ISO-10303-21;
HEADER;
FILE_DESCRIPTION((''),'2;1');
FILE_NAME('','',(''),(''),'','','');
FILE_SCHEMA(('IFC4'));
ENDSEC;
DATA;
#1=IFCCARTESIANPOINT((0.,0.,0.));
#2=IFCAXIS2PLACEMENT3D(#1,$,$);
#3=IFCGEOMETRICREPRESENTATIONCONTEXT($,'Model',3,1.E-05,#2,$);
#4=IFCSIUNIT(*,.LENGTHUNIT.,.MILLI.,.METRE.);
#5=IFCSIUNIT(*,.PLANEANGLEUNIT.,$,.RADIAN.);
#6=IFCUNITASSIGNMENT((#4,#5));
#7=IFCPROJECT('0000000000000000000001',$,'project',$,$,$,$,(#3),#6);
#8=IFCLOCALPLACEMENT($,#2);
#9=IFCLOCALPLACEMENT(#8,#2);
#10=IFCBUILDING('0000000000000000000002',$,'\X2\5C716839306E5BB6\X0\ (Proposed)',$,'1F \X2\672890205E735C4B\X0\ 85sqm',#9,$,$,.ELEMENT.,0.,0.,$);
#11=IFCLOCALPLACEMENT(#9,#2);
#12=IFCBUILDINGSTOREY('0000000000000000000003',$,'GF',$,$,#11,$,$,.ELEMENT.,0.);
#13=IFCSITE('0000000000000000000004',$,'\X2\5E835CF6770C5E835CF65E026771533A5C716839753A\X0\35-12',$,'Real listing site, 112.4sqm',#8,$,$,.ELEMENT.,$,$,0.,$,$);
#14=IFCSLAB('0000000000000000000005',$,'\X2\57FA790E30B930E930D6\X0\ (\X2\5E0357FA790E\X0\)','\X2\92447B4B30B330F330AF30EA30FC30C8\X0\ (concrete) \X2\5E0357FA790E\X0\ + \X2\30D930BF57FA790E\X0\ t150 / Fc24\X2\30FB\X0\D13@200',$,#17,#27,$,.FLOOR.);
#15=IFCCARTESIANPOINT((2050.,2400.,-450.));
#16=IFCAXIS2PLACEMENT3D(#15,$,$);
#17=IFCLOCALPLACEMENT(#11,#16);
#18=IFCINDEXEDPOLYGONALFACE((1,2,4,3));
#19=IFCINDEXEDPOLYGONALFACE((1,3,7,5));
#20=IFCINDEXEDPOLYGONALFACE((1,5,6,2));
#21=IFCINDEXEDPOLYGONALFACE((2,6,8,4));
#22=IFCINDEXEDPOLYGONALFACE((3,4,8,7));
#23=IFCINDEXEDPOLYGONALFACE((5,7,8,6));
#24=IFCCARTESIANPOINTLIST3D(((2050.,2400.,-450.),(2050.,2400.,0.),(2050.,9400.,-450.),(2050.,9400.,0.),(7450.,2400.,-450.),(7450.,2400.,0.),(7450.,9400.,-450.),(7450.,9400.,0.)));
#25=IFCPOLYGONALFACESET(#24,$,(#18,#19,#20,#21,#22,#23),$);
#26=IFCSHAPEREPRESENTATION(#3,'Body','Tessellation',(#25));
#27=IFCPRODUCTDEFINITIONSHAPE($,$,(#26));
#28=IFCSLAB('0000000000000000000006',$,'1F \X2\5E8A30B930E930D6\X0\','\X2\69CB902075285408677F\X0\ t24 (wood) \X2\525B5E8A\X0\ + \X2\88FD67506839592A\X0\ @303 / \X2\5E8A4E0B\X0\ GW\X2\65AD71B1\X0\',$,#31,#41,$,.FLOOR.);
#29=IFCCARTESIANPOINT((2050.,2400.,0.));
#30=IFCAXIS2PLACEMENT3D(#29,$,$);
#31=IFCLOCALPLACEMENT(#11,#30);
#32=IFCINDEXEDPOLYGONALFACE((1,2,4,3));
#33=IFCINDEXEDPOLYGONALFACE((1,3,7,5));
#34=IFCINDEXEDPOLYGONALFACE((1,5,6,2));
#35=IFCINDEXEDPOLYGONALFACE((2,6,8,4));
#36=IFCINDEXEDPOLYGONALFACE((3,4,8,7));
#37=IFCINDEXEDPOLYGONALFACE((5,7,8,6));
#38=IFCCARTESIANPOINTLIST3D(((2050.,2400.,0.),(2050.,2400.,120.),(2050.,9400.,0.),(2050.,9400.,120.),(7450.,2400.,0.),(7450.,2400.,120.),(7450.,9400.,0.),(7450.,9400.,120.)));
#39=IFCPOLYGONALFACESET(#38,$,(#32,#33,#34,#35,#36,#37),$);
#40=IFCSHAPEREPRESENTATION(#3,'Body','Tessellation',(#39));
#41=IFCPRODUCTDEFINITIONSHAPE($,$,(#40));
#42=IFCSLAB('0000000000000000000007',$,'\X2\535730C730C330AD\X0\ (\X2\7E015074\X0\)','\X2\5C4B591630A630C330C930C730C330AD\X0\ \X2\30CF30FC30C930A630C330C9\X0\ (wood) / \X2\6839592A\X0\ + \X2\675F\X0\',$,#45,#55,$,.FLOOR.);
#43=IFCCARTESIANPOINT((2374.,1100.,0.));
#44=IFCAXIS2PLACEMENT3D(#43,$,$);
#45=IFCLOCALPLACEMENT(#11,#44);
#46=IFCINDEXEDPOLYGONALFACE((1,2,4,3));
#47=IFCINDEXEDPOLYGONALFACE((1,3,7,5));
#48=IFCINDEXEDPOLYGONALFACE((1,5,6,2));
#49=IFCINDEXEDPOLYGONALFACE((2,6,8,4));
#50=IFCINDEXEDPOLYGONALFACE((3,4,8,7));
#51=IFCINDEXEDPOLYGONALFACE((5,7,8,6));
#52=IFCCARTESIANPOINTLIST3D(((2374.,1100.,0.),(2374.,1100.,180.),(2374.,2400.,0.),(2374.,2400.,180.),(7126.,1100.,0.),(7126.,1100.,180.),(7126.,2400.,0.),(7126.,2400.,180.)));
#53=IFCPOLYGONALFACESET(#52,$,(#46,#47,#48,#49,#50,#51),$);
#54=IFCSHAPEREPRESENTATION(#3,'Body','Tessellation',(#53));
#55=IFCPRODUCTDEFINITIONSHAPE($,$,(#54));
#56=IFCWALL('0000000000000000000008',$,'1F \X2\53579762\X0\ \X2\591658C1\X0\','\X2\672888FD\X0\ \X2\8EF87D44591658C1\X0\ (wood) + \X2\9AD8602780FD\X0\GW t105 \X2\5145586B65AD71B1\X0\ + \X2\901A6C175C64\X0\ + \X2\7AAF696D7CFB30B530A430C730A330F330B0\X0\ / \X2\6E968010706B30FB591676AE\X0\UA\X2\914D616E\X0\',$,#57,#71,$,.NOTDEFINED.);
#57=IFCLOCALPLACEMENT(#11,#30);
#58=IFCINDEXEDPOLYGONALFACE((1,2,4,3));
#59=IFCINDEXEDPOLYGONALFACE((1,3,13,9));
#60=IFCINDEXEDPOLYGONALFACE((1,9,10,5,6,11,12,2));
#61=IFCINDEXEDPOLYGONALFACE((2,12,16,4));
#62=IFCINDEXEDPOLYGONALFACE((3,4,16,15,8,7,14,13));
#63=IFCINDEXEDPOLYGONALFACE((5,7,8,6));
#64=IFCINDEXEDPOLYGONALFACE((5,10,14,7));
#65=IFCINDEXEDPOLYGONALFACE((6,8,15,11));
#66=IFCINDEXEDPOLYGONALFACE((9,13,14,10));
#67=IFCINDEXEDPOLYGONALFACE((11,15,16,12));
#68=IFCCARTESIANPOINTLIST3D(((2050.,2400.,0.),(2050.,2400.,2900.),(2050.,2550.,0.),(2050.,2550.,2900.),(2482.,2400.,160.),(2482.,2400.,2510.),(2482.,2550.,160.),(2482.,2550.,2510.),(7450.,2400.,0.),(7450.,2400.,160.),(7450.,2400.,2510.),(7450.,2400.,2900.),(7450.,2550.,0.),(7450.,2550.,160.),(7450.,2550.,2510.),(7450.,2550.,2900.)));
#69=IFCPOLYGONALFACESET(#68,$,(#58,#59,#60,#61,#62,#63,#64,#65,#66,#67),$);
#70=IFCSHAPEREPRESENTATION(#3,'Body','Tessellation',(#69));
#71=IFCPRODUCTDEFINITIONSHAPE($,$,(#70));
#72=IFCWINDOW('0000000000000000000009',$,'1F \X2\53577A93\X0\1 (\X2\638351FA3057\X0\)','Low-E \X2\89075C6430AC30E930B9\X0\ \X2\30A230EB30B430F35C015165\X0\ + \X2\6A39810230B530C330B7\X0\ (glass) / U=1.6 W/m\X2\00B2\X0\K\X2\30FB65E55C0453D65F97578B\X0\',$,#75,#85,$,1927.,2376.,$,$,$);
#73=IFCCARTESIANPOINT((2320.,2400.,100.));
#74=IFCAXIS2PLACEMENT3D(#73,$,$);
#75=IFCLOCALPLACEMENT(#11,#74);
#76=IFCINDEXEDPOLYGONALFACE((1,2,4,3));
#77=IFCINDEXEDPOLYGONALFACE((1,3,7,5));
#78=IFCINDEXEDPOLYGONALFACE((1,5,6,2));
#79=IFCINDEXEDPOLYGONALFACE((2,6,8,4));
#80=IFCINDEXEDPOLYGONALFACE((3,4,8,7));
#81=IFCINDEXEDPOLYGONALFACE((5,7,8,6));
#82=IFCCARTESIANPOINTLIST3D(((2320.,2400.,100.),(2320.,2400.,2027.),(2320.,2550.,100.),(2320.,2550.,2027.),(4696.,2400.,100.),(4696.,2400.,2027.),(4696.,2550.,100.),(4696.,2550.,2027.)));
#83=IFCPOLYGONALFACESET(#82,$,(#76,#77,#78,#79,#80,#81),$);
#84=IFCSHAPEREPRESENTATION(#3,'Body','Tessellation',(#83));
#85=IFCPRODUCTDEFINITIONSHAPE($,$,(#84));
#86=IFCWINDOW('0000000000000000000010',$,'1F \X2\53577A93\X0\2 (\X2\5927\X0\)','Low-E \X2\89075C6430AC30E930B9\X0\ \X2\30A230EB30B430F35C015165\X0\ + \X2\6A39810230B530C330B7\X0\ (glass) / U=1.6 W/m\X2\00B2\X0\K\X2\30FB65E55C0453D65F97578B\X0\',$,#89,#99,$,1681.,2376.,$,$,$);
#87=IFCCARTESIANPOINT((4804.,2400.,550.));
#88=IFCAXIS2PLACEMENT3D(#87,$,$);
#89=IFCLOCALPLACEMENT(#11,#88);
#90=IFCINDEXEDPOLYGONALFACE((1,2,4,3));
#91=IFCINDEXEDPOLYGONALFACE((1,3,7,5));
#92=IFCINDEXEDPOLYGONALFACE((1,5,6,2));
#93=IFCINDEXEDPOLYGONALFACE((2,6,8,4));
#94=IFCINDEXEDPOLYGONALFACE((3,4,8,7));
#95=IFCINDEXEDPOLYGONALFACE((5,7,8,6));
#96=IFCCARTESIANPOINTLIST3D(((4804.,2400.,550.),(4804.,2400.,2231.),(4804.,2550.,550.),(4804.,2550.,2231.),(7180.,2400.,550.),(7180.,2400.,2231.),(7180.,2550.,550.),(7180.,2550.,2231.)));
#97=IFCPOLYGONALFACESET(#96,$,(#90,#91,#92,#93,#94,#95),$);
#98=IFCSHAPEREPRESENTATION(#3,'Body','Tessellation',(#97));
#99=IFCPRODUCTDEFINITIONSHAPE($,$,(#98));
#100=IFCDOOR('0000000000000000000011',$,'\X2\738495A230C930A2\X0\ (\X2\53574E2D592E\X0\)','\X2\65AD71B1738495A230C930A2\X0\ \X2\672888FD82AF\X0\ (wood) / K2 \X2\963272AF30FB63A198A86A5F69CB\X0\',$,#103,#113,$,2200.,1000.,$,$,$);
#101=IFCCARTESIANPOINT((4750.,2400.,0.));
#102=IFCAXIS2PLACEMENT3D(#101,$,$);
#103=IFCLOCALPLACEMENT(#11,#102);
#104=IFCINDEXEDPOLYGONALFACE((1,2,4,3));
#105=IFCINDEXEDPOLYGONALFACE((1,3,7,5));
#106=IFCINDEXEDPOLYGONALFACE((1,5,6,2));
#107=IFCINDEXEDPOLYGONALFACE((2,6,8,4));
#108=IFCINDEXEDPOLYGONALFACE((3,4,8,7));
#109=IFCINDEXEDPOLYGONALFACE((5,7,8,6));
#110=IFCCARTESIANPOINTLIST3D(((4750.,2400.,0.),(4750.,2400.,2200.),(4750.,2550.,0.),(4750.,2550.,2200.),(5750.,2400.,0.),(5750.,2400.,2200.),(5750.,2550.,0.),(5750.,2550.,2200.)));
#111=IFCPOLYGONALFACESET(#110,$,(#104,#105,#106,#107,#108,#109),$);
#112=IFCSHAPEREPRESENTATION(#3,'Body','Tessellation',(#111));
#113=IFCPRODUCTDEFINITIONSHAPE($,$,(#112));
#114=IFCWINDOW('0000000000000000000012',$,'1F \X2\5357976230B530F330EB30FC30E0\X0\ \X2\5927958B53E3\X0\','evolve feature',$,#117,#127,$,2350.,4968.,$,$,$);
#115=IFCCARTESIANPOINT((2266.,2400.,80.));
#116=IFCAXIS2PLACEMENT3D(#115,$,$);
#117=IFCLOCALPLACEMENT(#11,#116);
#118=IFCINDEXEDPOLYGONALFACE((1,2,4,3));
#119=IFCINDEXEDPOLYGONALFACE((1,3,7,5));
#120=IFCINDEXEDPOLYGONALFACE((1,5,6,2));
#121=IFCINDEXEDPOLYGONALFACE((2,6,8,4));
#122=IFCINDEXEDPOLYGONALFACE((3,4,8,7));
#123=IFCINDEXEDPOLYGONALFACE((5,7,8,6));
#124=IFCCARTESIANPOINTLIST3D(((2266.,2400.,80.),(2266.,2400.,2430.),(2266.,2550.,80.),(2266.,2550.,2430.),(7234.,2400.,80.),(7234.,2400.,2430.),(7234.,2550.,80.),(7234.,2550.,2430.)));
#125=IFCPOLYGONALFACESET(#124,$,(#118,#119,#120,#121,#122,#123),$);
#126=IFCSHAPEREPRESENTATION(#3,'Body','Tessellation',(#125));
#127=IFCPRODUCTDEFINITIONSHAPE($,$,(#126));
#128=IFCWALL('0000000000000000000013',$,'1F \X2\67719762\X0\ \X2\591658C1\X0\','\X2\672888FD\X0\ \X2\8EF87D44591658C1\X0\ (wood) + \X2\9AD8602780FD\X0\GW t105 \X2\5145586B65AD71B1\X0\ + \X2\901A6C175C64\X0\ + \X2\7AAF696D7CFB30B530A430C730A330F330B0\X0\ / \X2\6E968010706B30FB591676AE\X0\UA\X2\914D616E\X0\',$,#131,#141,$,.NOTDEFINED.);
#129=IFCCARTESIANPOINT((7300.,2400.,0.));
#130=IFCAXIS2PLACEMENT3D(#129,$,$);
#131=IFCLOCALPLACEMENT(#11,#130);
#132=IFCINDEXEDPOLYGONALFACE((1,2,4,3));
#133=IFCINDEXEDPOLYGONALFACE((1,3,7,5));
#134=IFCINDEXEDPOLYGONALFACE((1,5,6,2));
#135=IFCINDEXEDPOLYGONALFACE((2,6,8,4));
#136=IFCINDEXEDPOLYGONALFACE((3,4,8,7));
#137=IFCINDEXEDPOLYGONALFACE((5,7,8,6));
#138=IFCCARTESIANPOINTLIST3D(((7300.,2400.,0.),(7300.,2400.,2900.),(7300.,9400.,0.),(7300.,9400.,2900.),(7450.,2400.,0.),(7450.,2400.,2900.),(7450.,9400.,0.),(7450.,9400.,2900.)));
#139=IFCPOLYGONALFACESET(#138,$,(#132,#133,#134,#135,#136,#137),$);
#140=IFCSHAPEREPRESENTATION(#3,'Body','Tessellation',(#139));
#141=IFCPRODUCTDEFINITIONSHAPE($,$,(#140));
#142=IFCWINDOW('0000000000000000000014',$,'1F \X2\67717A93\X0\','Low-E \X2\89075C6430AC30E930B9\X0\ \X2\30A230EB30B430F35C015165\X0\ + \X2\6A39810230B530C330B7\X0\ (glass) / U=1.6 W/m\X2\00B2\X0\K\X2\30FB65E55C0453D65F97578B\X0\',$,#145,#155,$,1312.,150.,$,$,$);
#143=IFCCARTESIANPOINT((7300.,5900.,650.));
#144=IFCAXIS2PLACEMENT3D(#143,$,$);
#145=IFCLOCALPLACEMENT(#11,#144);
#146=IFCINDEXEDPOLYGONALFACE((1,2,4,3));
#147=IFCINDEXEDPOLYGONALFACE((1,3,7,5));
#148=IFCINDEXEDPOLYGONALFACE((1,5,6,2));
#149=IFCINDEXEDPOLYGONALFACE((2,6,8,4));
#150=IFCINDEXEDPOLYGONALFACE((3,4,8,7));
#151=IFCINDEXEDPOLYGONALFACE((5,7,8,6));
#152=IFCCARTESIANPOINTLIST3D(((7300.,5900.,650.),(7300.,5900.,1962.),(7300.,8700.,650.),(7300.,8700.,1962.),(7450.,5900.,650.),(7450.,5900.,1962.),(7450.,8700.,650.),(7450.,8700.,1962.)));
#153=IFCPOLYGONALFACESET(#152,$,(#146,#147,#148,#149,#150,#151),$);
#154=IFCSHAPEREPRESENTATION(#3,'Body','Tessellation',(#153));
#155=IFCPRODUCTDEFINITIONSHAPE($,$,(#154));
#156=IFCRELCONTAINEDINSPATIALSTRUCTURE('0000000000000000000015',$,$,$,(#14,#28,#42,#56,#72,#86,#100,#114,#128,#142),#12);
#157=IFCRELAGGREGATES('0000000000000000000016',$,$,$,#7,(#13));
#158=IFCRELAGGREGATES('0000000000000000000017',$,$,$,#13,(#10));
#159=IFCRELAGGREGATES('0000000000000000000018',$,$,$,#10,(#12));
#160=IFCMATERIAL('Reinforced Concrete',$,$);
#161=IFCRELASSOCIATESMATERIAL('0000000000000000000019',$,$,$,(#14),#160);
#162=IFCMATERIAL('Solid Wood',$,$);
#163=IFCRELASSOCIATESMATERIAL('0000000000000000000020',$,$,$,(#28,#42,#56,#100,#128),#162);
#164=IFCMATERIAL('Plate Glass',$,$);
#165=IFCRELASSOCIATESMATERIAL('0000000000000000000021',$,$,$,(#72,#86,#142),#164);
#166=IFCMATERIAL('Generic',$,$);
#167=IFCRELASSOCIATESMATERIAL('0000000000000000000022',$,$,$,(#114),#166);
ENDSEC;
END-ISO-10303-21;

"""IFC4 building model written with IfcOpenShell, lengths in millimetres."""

from ifc_helpers import new_model, si_unit, frame, frame_2d, origin, place, context, project, spatial, rectangle, extrude, material, element, fill, save


model = new_model("IFC4")

# Units and contexts
model_context = context("Model", 3, precision=1e-05, world=origin())
ifc_project = project(units=[si_unit("LENGTHUNIT", "METRE", prefix="MILLI"), si_unit("PLANEANGLEUNIT", "RADIAN")], contexts=[model_context])

# Site, building, storey
site_placement = place(None, origin())
site = spatial("IfcSite", under=ifc_project, at=site_placement, Name="広島県広島市東区山根町35-12", ObjectType="Real listing site, 112.4sqm", CompositionType="ELEMENT", RefElevation=0.0)
building_placement = place(site_placement, origin())
building = spatial("IfcBuilding", under=site, at=building_placement, Name="山根の家 (Proposed)", ObjectType="1F 木造平屋 85sqm", CompositionType="ELEMENT", ElevationOfRefHeight=0.0, ElevationOfTerrain=0.0)
storey_placement = place(building_placement, origin())
storey = spatial("IfcBuildingStorey", under=building, at=storey_placement, Name="GF", CompositionType="ELEMENT", Elevation=0.0)

# Slabs
ifc_material_1 = material(Name="Reinforced Concrete")
slab_1_placement = place(storey_placement, frame((2050.0, 2400.0, -450.0)))
element("IfcSlab", 1, at=slab_1_placement, inside=storey, material=ifc_material_1, Name="基礎スラブ (布基礎)", Description="鉄筋コンクリート (concrete) 布基礎 + ベタ基礎 t150 / Fc24・D13@200", PredefinedType="FLOOR", context=model_context, shape_type="SweptSolid", body=[
    extrude(rectangle(XDim=5400.0, YDim=7000.0, at=frame_2d((2700.0, 3500.0))), frame((2050.0, 2400.0, -450.0)), (0.0, 0.0, 1.0), 450.0),
])
ifc_material_2 = material(Name="Solid Wood")
slab_2_placement = place(storey_placement, frame((2050.0, 2400.0, 0.0)))
element("IfcSlab", 2, at=slab_2_placement, inside=storey, material=ifc_material_2, Name="1F 床スラブ", Description="構造用合板 t24 (wood) 剛床 + 製材根太 @303 / 床下 GW断熱", PredefinedType="FLOOR", context=model_context, shape_type="SweptSolid", body=[
    extrude(rectangle(XDim=5400.0, YDim=7000.0, at=frame_2d((2700.0, 3500.0))), frame((2050.0, 2400.0, 0.0)), (0.0, 0.0, 1.0), 120.0),
])
slab_3_placement = place(storey_placement, frame((2374.0, 1100.0, 0.0)))
element("IfcSlab", 3, at=slab_3_placement, inside=storey, material=ifc_material_2, Name="南デッキ (縁側)", Description="屋外ウッドデッキ ハードウッド (wood) / 根太 + 束", PredefinedType="FLOOR", context=model_context, shape_type="SweptSolid", body=[
    extrude(rectangle(XDim=4752.0, YDim=1300.0, at=frame_2d((2376.0, 650.0))), frame((2374.0, 1100.0, 0.0)), (0.0, 0.0, 1.0), 180.0),
])
ifc_material_3 = material(Name="Generic")

# Wall, openings, windows, door
wall_1_placement = place(storey_placement, frame((2050.0, 2400.0, 0.0)))
wall_1 = element("IfcWall", 4, at=wall_1_placement, inside=storey, material=ifc_material_2, Name="1F 南面 外壁", Description="木製 軸組外壁 (wood) + 高性能GW t105 充填断熱 + 通気層 + 窯業系サイディング / 準耐火・外皮UA配慮", PredefinedType="NOTDEFINED", context=model_context, shape_type="SweptSolid", body=[
    extrude(rectangle(XDim=5400.0, YDim=150.0, at=frame_2d((2700.0, 75.0))), frame((2050.0, 2400.0, 0.0)), (0.0, 0.0, 1.0), 2900.0),
])
opening_1_placement = place(storey_placement, frame((2320.0, 2400.0, 100.0)))
opening_1 = element("IfcOpeningElement", 5, at=opening_1_placement, cuts=wall_1, PredefinedType="NOTDEFINED", context=model_context, shape_type="SweptSolid", body=[
    extrude(rectangle(XDim=2376.0, YDim=150.0, at=frame_2d((1188.0, 75.0))), frame((2320.0, 2400.0, 100.0)), (0.0, 0.0, 1.0), 1927.0),
])
opening_2_placement = place(storey_placement, frame((4804.0, 2400.0, 550.0)))
opening_2 = element("IfcOpeningElement", 6, at=opening_2_placement, cuts=wall_1, PredefinedType="NOTDEFINED", context=model_context, shape_type="SweptSolid", body=[
    extrude(rectangle(XDim=2376.0, YDim=150.0, at=frame_2d((1188.0, 75.0))), frame((4804.0, 2400.0, 550.0)), (0.0, 0.0, 1.0), 1681.0),
])
opening_3_placement = place(storey_placement, frame((4750.0, 2400.0, 0.0)))
opening_3 = element("IfcOpeningElement", 7, at=opening_3_placement, cuts=wall_1, PredefinedType="NOTDEFINED", context=model_context, shape_type="SweptSolid", body=[
    extrude(rectangle(XDim=1000.0, YDim=150.0, at=frame_2d((500.0, 75.0))), frame((4750.0, 2400.0, 0.0)), (0.0, 0.0, 1.0), 2200.0),
])
opening_4_placement = place(storey_placement, frame((2266.0, 2400.0, 80.0)))
opening_4 = element("IfcOpeningElement", 8, at=opening_4_placement, cuts=wall_1, PredefinedType="NOTDEFINED", context=model_context, shape_type="SweptSolid", body=[
    extrude(rectangle(XDim=4968.0, YDim=150.0, at=frame_2d((2484.0, 75.0))), frame((2266.0, 2400.0, 80.0)), (0.0, 0.0, 1.0), 2350.0),
])
ifc_material_4 = material(Name="Plate Glass")
window_1_placement = place(storey_placement, frame((2320.0, 2400.0, 100.0)))
window_1 = element("IfcWindow", 9, at=window_1_placement, inside=storey, material=ifc_material_4, Name="1F 南窓1 (掃出し)", Description="Low-E 複層ガラス アルゴン封入 + 樹脂サッシ (glass) / U=1.6 W/m²K・日射取得型", OverallHeight=1927.0, OverallWidth=2376.0, context=model_context, shape_type="SweptSolid", body=[
    extrude(rectangle(XDim=2376.0, YDim=150.0, at=frame_2d((1188.0, 75.0))), frame((2320.0, 2400.0, 100.0)), (0.0, 0.0, 1.0), 1927.0),
])
fill(opening_1, window_1)
window_2_placement = place(storey_placement, frame((4804.0, 2400.0, 550.0)))
window_2 = element("IfcWindow", 10, at=window_2_placement, inside=storey, material=ifc_material_4, Name="1F 南窓2 (大)", Description="Low-E 複層ガラス アルゴン封入 + 樹脂サッシ (glass) / U=1.6 W/m²K・日射取得型", OverallHeight=1681.0, OverallWidth=2376.0, context=model_context, shape_type="SweptSolid", body=[
    extrude(rectangle(XDim=2376.0, YDim=150.0, at=frame_2d((1188.0, 75.0))), frame((4804.0, 2400.0, 550.0)), (0.0, 0.0, 1.0), 1681.0),
])
fill(opening_2, window_2)
door_placement = place(storey_placement, frame((4750.0, 2400.0, 0.0)))
door = element("IfcDoor", 11, at=door_placement, inside=storey, material=ifc_material_2, Name="玄関ドア (南中央)", Description="断熱玄関ドア 木製芯 (wood) / K2 防犯・採風機構", OverallHeight=2200.0, OverallWidth=1000.0, context=model_context, shape_type="SweptSolid", body=[
    extrude(rectangle(XDim=1000.0, YDim=150.0, at=frame_2d((500.0, 75.0))), frame((4750.0, 2400.0, 0.0)), (0.0, 0.0, 1.0), 2200.0),
])
fill(opening_3, door)
window_3_placement = place(storey_placement, frame((2266.0, 2400.0, 80.0)))
window_3 = element("IfcWindow", 12, at=window_3_placement, inside=storey, material=ifc_material_3, Name="1F 南面サンルーム 大開口", Description="evolve feature", OverallHeight=2350.0, OverallWidth=4968.0, context=model_context, shape_type="SweptSolid", body=[
    extrude(rectangle(XDim=4968.0, YDim=150.0, at=frame_2d((2484.0, 75.0))), frame((2266.0, 2400.0, 80.0)), (0.0, 0.0, 1.0), 2350.0),
])
fill(opening_4, window_3)

# Wall, opening, window
wall_2_placement = place(storey_placement, frame((7300.0, 2400.0, 0.0)))
wall_2 = element("IfcWall", 13, at=wall_2_placement, inside=storey, material=ifc_material_2, Name="1F 東面 外壁", Description="木製 軸組外壁 (wood) + 高性能GW t105 充填断熱 + 通気層 + 窯業系サイディング / 準耐火・外皮UA配慮", PredefinedType="NOTDEFINED", context=model_context, shape_type="SweptSolid", body=[
    extrude(rectangle(XDim=150.0, YDim=7000.0, at=frame_2d((75.0, 3500.0))), frame((7300.0, 2400.0, 0.0)), (0.0, 0.0, 1.0), 2900.0),
])
opening_5_placement = place(storey_placement, frame((7300.0, 5900.0, 650.0)))
opening_5 = element("IfcOpeningElement", 14, at=opening_5_placement, cuts=wall_2, PredefinedType="NOTDEFINED", context=model_context, shape_type="SweptSolid", body=[
    extrude(rectangle(XDim=150.0, YDim=2800.0, at=frame_2d((75.0, 1400.0))), frame((7300.0, 5900.0, 650.0)), (0.0, 0.0, 1.0), 1312.0),
])
window_4_placement = place(storey_placement, frame((7300.0, 5900.0, 650.0)))
window_4 = element("IfcWindow", 15, at=window_4_placement, inside=storey, material=ifc_material_4, Name="1F 東窓", Description="Low-E 複層ガラス アルゴン封入 + 樹脂サッシ (glass) / U=1.6 W/m²K・日射取得型", OverallHeight=1312.0, OverallWidth=150.0, context=model_context, shape_type="SweptSolid", body=[
    extrude(rectangle(XDim=150.0, YDim=2800.0, at=frame_2d((75.0, 1400.0))), frame((7300.0, 5900.0, 650.0)), (0.0, 0.0, 1.0), 1312.0),
])
fill(opening_5, window_4)

save(model, "model.ifc")
